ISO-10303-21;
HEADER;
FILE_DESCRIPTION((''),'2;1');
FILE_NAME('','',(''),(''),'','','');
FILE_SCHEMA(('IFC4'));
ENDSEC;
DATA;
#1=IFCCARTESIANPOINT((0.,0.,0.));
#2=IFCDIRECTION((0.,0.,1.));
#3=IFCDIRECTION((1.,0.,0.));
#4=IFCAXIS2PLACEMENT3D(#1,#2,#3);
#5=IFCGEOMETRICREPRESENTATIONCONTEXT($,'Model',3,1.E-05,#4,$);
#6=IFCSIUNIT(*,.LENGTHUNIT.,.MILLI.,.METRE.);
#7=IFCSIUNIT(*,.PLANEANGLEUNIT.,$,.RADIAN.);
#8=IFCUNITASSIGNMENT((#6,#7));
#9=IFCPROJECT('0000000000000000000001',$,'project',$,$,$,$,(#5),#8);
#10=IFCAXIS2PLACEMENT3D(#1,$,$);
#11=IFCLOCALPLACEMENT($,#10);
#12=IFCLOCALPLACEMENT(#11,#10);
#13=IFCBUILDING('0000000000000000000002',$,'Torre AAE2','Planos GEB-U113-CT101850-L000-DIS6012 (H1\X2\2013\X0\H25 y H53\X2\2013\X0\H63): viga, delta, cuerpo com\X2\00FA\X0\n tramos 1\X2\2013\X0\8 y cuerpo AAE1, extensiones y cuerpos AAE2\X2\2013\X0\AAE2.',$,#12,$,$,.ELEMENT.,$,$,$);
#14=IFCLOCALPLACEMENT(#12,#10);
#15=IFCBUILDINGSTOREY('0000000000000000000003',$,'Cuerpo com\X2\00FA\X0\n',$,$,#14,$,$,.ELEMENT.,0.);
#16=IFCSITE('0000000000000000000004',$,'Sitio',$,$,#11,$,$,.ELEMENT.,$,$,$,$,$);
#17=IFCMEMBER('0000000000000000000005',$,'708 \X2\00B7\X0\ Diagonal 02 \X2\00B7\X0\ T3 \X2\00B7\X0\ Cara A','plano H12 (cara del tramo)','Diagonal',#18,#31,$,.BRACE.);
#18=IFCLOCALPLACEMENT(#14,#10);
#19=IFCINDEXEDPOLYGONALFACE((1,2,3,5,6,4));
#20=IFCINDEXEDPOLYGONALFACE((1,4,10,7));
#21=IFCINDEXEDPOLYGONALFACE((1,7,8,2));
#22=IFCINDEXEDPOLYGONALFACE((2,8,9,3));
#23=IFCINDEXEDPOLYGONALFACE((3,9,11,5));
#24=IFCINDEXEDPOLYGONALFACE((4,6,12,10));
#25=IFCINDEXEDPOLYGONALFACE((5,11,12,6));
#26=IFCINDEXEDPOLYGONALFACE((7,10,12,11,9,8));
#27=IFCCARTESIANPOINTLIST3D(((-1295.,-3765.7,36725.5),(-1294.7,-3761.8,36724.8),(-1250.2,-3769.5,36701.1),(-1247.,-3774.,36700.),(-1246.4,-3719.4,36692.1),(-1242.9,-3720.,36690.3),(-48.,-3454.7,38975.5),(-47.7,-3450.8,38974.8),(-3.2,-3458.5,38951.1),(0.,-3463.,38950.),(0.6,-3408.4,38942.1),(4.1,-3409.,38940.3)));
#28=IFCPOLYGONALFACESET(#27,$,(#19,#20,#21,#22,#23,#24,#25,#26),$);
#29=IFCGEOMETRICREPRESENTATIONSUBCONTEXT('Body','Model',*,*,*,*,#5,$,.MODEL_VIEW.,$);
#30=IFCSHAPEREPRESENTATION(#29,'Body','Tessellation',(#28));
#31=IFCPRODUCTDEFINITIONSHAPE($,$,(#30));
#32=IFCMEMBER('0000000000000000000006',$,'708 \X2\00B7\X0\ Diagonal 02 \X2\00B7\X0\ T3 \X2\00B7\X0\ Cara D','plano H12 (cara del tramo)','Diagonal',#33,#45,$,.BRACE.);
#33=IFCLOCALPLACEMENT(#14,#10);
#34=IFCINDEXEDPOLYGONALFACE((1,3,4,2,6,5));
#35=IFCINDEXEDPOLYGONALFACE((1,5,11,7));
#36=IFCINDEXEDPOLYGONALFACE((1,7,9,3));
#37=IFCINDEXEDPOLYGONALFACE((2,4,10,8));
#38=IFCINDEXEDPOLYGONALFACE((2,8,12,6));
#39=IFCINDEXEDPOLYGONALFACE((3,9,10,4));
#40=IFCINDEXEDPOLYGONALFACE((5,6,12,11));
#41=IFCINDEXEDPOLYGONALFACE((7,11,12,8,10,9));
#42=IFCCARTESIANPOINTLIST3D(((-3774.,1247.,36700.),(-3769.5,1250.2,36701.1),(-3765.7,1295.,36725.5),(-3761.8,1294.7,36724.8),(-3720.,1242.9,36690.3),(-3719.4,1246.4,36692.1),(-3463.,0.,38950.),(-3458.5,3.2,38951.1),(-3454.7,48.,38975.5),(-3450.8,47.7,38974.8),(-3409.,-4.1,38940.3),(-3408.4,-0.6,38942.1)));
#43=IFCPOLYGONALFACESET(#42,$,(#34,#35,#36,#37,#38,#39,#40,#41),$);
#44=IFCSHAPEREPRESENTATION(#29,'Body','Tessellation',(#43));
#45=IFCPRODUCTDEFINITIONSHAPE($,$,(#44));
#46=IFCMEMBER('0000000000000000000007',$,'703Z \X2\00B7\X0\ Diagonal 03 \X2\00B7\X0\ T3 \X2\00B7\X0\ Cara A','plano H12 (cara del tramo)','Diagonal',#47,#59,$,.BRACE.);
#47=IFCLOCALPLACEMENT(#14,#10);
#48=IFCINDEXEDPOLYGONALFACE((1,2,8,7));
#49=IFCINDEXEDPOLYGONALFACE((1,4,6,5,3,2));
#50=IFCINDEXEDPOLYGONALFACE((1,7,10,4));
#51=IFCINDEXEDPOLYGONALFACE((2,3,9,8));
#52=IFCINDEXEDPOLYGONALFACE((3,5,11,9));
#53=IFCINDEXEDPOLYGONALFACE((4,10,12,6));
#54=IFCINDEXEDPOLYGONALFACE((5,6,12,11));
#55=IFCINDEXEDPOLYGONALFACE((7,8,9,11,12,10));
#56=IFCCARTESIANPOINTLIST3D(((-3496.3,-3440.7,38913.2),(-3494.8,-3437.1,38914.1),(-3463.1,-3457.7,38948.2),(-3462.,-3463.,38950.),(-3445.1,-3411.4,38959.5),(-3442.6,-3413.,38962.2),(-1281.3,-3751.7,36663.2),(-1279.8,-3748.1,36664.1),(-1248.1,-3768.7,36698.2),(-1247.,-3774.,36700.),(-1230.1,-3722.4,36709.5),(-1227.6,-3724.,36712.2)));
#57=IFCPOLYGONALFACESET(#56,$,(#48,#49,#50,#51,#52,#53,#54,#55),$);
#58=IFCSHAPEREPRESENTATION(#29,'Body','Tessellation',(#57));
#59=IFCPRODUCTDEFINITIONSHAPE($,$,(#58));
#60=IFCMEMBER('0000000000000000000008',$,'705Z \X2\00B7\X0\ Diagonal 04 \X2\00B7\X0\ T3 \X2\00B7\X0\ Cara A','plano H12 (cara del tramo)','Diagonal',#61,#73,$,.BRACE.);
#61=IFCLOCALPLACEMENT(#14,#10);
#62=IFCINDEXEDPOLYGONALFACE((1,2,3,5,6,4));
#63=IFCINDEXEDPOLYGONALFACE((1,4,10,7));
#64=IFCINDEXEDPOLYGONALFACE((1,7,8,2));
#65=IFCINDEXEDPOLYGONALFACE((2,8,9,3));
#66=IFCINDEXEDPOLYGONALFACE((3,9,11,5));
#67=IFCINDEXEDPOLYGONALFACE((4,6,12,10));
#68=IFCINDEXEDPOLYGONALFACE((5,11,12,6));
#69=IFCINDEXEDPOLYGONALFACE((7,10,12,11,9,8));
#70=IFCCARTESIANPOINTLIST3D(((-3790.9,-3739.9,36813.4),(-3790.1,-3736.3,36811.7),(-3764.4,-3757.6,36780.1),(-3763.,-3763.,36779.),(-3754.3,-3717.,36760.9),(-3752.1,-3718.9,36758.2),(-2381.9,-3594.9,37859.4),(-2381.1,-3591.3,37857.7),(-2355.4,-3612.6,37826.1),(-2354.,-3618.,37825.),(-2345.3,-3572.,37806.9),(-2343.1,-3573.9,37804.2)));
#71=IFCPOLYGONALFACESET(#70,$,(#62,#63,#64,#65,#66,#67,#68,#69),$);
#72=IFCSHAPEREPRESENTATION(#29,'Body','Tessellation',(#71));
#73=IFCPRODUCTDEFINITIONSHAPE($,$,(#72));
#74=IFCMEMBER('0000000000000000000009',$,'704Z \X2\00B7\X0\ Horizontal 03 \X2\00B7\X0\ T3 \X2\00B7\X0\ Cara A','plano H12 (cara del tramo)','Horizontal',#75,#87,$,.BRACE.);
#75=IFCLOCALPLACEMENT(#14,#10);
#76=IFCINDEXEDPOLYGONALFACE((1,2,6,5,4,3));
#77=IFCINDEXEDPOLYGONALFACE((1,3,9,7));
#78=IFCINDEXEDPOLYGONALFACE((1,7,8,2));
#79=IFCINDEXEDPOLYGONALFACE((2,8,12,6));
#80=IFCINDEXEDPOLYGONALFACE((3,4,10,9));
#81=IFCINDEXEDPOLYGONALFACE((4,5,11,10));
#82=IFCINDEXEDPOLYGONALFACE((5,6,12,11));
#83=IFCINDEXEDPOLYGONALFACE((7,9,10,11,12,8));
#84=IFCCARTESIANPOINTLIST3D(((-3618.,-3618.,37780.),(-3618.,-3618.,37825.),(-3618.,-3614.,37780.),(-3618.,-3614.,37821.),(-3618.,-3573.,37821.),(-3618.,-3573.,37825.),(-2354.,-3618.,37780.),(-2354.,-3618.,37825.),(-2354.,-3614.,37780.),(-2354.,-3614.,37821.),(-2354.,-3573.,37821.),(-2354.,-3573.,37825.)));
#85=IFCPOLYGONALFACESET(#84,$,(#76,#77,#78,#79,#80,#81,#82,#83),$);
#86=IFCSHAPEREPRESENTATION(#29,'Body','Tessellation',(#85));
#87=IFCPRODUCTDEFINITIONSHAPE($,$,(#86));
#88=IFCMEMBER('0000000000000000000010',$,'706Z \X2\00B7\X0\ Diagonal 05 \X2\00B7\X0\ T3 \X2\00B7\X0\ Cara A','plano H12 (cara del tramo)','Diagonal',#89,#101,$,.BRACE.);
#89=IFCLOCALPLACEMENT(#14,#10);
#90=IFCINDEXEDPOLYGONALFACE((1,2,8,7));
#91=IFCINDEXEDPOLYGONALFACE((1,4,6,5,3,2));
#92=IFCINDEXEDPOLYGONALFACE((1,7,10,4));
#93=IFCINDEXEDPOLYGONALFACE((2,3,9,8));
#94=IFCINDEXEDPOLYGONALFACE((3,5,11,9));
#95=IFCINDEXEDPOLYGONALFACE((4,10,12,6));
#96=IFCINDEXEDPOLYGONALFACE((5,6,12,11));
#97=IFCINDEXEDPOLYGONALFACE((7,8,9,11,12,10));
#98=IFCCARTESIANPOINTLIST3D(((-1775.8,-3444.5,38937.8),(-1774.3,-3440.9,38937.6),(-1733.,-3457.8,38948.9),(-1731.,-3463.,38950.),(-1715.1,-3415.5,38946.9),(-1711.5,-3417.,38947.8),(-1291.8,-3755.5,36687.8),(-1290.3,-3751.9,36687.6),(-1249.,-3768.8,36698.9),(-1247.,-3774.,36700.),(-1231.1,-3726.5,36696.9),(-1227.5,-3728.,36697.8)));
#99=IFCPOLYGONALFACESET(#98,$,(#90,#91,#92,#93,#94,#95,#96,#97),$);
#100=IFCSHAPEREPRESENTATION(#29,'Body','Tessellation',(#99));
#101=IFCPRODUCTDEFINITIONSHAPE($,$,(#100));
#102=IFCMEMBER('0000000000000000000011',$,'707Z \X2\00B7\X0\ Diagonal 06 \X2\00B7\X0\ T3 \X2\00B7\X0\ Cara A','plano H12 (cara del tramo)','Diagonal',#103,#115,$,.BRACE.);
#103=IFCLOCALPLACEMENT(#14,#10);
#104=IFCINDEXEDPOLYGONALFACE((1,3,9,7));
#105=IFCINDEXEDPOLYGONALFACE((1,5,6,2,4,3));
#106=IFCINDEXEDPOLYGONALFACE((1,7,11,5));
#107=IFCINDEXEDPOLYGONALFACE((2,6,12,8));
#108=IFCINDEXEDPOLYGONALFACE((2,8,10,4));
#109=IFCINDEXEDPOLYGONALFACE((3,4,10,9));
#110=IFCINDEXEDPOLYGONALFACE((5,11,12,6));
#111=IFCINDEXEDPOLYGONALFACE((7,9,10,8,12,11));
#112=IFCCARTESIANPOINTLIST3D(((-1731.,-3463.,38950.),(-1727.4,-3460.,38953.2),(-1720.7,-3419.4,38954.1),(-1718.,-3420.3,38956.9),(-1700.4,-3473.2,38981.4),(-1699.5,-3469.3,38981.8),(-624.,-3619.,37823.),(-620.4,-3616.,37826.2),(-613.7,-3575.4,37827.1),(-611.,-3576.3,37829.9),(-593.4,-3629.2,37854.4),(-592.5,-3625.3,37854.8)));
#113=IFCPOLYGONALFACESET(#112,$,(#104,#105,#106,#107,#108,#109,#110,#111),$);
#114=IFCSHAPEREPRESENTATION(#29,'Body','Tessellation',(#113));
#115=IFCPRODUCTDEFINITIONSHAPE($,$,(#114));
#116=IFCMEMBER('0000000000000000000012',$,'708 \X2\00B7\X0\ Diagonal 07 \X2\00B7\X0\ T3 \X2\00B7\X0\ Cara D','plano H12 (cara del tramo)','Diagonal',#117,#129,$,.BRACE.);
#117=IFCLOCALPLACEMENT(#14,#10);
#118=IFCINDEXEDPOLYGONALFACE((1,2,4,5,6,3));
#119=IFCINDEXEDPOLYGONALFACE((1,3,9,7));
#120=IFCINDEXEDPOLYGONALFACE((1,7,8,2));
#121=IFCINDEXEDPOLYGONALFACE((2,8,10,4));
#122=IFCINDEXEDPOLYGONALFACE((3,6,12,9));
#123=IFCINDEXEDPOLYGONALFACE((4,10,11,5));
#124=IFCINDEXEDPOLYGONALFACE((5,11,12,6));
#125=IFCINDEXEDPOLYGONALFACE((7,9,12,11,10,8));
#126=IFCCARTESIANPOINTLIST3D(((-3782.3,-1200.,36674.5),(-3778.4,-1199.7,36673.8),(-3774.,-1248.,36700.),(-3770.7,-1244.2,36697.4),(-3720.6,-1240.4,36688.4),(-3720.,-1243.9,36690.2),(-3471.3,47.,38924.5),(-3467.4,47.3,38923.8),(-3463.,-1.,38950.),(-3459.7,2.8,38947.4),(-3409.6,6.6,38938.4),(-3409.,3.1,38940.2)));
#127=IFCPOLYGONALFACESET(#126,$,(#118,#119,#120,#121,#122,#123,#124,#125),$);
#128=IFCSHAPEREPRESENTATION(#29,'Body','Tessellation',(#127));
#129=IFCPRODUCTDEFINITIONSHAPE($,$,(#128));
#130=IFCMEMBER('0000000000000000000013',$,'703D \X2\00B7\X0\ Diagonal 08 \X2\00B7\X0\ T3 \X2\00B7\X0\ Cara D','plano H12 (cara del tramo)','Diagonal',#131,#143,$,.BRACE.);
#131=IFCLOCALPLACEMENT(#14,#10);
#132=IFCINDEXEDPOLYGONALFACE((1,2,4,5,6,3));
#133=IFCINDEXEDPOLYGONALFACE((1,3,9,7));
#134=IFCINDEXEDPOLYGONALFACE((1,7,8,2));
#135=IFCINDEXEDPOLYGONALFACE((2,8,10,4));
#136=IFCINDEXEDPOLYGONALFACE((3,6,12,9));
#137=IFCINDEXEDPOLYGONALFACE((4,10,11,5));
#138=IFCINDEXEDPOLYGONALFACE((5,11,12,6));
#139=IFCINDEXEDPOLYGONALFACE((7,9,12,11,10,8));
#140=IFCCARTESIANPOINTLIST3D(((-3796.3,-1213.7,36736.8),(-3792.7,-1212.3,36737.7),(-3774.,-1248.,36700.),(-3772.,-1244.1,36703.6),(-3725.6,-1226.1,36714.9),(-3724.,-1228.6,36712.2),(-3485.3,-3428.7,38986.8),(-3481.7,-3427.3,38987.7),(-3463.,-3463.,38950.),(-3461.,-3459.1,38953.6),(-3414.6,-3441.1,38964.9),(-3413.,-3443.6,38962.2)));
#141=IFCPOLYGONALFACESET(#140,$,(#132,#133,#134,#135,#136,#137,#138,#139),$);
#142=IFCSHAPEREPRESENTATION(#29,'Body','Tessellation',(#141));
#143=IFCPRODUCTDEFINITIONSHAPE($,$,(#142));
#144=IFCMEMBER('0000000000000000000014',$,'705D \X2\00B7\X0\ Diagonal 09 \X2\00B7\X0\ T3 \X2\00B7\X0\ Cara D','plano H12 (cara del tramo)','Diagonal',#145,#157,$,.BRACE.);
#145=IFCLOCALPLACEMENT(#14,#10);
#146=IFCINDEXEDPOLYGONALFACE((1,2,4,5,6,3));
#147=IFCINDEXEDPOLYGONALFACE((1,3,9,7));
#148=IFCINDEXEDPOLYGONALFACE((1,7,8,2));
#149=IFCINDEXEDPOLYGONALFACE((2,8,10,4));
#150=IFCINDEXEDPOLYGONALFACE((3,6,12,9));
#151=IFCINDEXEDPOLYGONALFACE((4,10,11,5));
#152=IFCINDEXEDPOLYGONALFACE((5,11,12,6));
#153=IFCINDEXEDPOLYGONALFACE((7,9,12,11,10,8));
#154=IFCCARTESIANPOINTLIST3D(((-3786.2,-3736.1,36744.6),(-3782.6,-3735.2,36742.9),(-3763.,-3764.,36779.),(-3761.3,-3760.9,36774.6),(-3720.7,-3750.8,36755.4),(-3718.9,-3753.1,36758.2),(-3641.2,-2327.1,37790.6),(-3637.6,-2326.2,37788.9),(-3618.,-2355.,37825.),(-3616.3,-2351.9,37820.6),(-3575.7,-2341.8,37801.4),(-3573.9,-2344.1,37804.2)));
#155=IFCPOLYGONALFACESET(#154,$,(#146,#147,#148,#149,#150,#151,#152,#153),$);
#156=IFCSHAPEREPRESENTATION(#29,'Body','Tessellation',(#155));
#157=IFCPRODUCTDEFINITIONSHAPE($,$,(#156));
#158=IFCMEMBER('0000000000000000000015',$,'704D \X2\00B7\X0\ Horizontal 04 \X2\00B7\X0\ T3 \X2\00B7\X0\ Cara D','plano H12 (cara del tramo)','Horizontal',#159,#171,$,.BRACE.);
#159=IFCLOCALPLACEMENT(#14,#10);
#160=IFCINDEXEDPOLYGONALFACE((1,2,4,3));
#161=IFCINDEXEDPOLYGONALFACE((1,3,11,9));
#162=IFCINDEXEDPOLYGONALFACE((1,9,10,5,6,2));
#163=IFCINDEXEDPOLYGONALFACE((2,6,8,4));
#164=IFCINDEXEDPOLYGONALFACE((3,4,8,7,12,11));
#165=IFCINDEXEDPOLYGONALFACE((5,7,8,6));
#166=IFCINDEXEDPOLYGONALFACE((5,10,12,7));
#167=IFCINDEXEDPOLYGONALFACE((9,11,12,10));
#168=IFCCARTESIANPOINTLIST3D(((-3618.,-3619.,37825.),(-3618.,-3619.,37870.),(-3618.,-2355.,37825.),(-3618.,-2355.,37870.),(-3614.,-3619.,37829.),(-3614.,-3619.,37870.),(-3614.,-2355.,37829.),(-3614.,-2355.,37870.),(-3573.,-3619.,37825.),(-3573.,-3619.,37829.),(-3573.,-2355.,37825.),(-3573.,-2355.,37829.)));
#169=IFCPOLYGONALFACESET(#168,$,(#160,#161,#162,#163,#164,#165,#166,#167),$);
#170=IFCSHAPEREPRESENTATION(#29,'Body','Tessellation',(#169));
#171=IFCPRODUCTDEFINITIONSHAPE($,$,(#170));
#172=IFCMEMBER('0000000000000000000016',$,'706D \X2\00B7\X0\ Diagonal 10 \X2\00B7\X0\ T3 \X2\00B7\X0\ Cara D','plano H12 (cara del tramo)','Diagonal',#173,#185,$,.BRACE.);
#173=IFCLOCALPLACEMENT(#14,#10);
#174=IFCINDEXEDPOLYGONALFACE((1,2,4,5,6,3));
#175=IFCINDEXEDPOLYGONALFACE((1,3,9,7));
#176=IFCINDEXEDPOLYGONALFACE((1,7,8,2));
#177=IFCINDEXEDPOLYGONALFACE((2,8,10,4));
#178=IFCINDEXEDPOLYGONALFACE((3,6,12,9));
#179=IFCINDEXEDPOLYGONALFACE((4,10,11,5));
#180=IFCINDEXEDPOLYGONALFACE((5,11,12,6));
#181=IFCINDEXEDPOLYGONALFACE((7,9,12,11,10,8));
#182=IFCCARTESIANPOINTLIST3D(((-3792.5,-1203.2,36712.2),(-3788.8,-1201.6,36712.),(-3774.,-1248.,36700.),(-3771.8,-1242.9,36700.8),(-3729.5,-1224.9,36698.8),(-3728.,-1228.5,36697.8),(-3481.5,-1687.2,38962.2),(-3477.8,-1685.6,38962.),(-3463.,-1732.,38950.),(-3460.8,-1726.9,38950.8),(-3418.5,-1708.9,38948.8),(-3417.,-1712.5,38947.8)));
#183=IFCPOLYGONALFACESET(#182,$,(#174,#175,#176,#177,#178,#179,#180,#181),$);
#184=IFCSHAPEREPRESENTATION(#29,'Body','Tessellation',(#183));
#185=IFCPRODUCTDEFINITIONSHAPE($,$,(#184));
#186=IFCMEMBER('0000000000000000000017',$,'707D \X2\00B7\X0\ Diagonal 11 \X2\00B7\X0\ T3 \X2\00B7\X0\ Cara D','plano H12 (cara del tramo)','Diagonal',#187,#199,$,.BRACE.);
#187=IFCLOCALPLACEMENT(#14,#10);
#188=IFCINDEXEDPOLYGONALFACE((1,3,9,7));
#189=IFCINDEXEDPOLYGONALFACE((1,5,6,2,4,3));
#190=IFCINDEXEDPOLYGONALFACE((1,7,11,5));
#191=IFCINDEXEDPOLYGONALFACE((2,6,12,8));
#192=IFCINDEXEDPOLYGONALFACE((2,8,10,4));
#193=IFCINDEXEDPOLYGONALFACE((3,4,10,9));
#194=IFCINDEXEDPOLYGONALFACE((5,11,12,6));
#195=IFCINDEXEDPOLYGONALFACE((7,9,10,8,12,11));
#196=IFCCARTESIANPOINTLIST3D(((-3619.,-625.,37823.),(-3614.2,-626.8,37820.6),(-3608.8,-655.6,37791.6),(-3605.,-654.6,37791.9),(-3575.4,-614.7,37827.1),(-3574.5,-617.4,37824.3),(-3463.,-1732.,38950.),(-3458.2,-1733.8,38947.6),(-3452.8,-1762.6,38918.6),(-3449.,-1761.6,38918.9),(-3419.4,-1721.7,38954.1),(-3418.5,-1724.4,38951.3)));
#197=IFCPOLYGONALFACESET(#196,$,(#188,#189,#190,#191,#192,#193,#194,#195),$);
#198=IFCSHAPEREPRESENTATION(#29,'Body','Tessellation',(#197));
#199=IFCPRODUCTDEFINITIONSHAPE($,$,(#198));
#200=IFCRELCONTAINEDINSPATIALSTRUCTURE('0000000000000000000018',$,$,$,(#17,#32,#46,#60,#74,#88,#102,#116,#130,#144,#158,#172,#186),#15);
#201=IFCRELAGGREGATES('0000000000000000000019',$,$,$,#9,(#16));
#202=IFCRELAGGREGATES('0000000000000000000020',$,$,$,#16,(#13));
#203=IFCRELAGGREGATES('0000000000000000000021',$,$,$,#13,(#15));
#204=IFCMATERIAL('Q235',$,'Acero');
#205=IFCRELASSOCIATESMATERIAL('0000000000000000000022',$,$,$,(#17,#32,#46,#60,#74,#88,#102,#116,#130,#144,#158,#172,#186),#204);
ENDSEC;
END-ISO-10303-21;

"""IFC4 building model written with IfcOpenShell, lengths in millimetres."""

from ifc_helpers import new_model, si_unit, frame, frame_2d, origin, origin_with_axes, place, context, subcontext, project, spatial, l_section, extrude, material, element, save


model = new_model("IFC4")

# Units and contexts
model_context = context("Model", 3, precision=1e-05, world=origin_with_axes())
body_context = subcontext(model_context, "Body", "Model", "MODEL_VIEW")
ifc_project = project(units=[si_unit("LENGTHUNIT", "METRE", prefix="MILLI"), si_unit("PLANEANGLEUNIT", "RADIAN")], contexts=[model_context])

# Site, building, storey
site_placement = place(None, origin())
site = spatial("IfcSite", under=ifc_project, at=site_placement, Name="Sitio", CompositionType="ELEMENT")
building_placement = place(site_placement, origin())
building = spatial("IfcBuilding", under=site, at=building_placement, Name="Torre AAE2", Description="Planos GEB-U113-CT101850-L000-DIS6012 (H1–H25 y H53–H63): viga, delta, cuerpo común tramos 1–8 y cuerpo AAE1, extensiones y cuerpos AAE2–AAE2.", CompositionType="ELEMENT")
storey_placement = place(building_placement, origin())
storey = spatial("IfcBuildingStorey", under=building, at=storey_placement, Name="Cuerpo común", CompositionType="ELEMENT", Elevation=0.0)

# Members
ifc_material_1 = material(Name="Q235", Category="Acero")
for number, where, z_axis, x_axis, name in (
    (1, (-1247.0, -3774.0, 36700.0), (0.481247, 0.120022, 0.868329), (0.075075, 0.981299, -0.177245), "708 · Diagonal 02 · T3 · Cara A"),
    (2, (-3774.0, 1247.0, 36700.0), (0.120022, -0.481247, 0.868329), (0.981299, -0.075075, -0.177245), "708 · Diagonal 02 · T3 · Cara D"),
):
    element("IfcMember", number, at=place(storey_placement, frame(where, z_axis=z_axis, x_axis=x_axis)), inside=storey, material=ifc_material_1, Name=name, Description="plano H12 (cara del tramo)", ObjectType="Diagonal", PredefinedType="BRACE", context=body_context, shape_type="SweptSolid", body=[
        extrude(l_section(Depth=55.0, Width=55.0, Thickness=4.0, at=frame_2d((27.5, 27.5))), None, (0.0, 0.0, 1.0), 2591.2),
    ])
member_1_placement = place(storey_placement, frame((-1247.0, -3774.0, 36700.0), z_axis=(-0.698164, 0.098027, 0.709196), x_axis=(0.35302, 0.908922, 0.221895)))
element("IfcMember", 3, at=member_1_placement, inside=storey, material=ifc_material_1, Name="703Z · Diagonal 03 · T3 · Cara A", Description="plano H12 (cara del tramo)", ObjectType="Diagonal", PredefinedType="BRACE", context=body_context, shape_type="SweptSolid", body=[
    extrude(l_section(Depth=55.0, Width=55.0, Thickness=4.0, at=frame_2d((27.5, 27.5))), None, (0.0, 0.0, 1.0), 3172.6),
])
member_2_placement = place(storey_placement, frame((-3763.0, -3763.0, 36779.0), z_axis=(0.800204, 0.082349, 0.594048), x_axis=(0.218321, 0.882566, -0.41643)))
element("IfcMember", 4, at=member_2_placement, inside=storey, material=ifc_material_1, Name="705Z · Diagonal 04 · T3 · Cara A", Description="plano H12 (cara del tramo)", ObjectType="Diagonal", PredefinedType="BRACE", context=body_context, shape_type="SweptSolid", body=[
    extrude(l_section(Depth=50.0, Width=50.0, Thickness=4.0, at=frame_2d((25.0, 25.0))), None, (0.0, 0.0, 1.0), 1760.8),
])
member_3_placement = place(storey_placement, frame((-2354.0, -3618.0, 37825.0), z_axis=(-1.0, 0.0, 0.0), x_axis=(0.0, 1.0, 0.0)))
element("IfcMember", 5, at=member_3_placement, inside=storey, material=ifc_material_1, Name="704Z · Horizontal 03 · T3 · Cara A", Description="plano H12 (cara del tramo)", ObjectType="Horizontal", PredefinedType="BRACE", context=body_context, shape_type="SweptSolid", body=[
    extrude(l_section(Depth=45.0, Width=45.0, Thickness=4.0, at=frame_2d((22.5, 22.5))), None, (0.0, 0.0, 1.0), 1264.0),
])
member_4_placement = place(storey_placement, frame((-1247.0, -3774.0, 36700.0), z_axis=(-0.208406, 0.133914, 0.968831), x_axis=(0.390206, 0.919714, -0.043187)))
element("IfcMember", 6, at=member_4_placement, inside=storey, material=ifc_material_1, Name="706Z · Diagonal 05 · T3 · Cara A", Description="plano H12 (cara del tramo)", ObjectType="Diagonal", PredefinedType="BRACE", context=body_context, shape_type="SweptSolid", body=[
    extrude(l_section(Depth=50.0, Width=50.0, Thickness=4.0, at=frame_2d((25.0, 25.0))), None, (0.0, 0.0, 1.0), 2322.4),
])
member_5_placement = place(storey_placement, frame((-1731.0, -3463.0, 38950.0), z_axis=(0.697356, -0.098272, -0.709955), x_axis=(0.228971, 0.969194, 0.090751)))
element("IfcMember", 7, at=member_5_placement, inside=storey, material=ifc_material_1, Name="707Z · Diagonal 06 · T3 · Cara A", Description="plano H12 (cara del tramo)", ObjectType="Diagonal", PredefinedType="BRACE", context=body_context, shape_type="SweptSolid", body=[
    extrude(l_section(Depth=45.0, Width=45.0, Thickness=4.0, at=frame_2d((22.5, 22.5))), None, (0.0, 0.0, 1.0), 1587.4),
])
member_6_placement = place(storey_placement, frame((-3774.0, -1248.0, 36700.0), z_axis=(0.120022, 0.481247, 0.868329), x_axis=(0.981263, 0.075287, -0.177358)))
element("IfcMember", 8, at=member_6_placement, inside=storey, material=ifc_material_1, Name="708 · Diagonal 07 · T3 · Cara D", Description="plano H12 (cara del tramo)", ObjectType="Diagonal", PredefinedType="BRACE", context=body_context, shape_type="SweptSolid", body=[
    extrude(l_section(Depth=55.0, Width=55.0, Thickness=4.0, at=frame_2d((27.5, 27.5))), None, (0.0, 0.0, 1.0), 2591.2),
])
member_7_placement = place(storey_placement, frame((-3774.0, -1248.0, 36700.0), z_axis=(0.098027, -0.698164, 0.709196), x_axis=(0.908861, 0.353114, 0.221997)))
element("IfcMember", 9, at=member_7_placement, inside=storey, material=ifc_material_1, Name="703D · Diagonal 08 · T3 · Cara D", Description="plano H12 (cara del tramo)", ObjectType="Diagonal", PredefinedType="BRACE", context=body_context, shape_type="SweptSolid", body=[
    extrude(l_section(Depth=55.0, Width=55.0, Thickness=4.0, at=frame_2d((27.5, 27.5))), None, (0.0, 0.0, 1.0), 3172.6),
])
member_8_placement = place(storey_placement, frame((-3763.0, -3764.0, 36779.0), z_axis=(0.082349, 0.800204, 0.594048), x_axis=(0.8825, 0.2184, -0.416528)))
element("IfcMember", 10, at=member_8_placement, inside=storey, material=ifc_material_1, Name="705D · Diagonal 09 · T3 · Cara D", Description="plano H12 (cara del tramo)", ObjectType="Diagonal", PredefinedType="BRACE", context=body_context, shape_type="SweptSolid", body=[
    extrude(l_section(Depth=50.0, Width=50.0, Thickness=4.0, at=frame_2d((25.0, 25.0))), None, (0.0, 0.0, 1.0), 1760.8),
])
member_9_placement = place(storey_placement, frame((-3618.0, -2355.0, 37825.0), z_axis=(0.0, -1.0, 0.0), x_axis=(1.0, 0.0, 0.0)))
element("IfcMember", 11, at=member_9_placement, inside=storey, material=ifc_material_1, Name="704D · Horizontal 04 · T3 · Cara D", Description="plano H12 (cara del tramo)", ObjectType="Horizontal", PredefinedType="BRACE", context=body_context, shape_type="SweptSolid", body=[
    extrude(l_section(Depth=45.0, Width=45.0, Thickness=4.0, at=frame_2d((22.5, 22.5))), None, (0.0, 0.0, 1.0), 1264.0),
])
member_10_placement = place(storey_placement, frame((-3774.0, -1248.0, 36700.0), z_axis=(0.133914, -0.208406, 0.968831), x_axis=(0.91963, 0.390411, -0.043131)))
element("IfcMember", 12, at=member_10_placement, inside=storey, material=ifc_material_1, Name="706D · Diagonal 10 · T3 · Cara D", Description="plano H12 (cara del tramo)", ObjectType="Diagonal", PredefinedType="BRACE", context=body_context, shape_type="SweptSolid", body=[
    extrude(l_section(Depth=50.0, Width=50.0, Thickness=4.0, at=frame_2d((25.0, 25.0))), None, (0.0, 0.0, 1.0), 2322.4),
])
member_11_placement = place(storey_placement, frame((-3463.0, -1732.0, 38950.0), z_axis=(-0.098272, 0.697356, -0.709955), x_axis=(0.969152, 0.229096, 0.090879)))
element("IfcMember", 13, at=member_11_placement, inside=storey, material=ifc_material_1, Name="707D · Diagonal 11 · T3 · Cara D", Description="plano H12 (cara del tramo)", ObjectType="Diagonal", PredefinedType="BRACE", context=body_context, shape_type="SweptSolid", body=[
    extrude(l_section(Depth=45.0, Width=45.0, Thickness=4.0, at=frame_2d((22.5, 22.5))), None, (0.0, 0.0, 1.0), 1587.4),
])

save(model, "model.ifc")
